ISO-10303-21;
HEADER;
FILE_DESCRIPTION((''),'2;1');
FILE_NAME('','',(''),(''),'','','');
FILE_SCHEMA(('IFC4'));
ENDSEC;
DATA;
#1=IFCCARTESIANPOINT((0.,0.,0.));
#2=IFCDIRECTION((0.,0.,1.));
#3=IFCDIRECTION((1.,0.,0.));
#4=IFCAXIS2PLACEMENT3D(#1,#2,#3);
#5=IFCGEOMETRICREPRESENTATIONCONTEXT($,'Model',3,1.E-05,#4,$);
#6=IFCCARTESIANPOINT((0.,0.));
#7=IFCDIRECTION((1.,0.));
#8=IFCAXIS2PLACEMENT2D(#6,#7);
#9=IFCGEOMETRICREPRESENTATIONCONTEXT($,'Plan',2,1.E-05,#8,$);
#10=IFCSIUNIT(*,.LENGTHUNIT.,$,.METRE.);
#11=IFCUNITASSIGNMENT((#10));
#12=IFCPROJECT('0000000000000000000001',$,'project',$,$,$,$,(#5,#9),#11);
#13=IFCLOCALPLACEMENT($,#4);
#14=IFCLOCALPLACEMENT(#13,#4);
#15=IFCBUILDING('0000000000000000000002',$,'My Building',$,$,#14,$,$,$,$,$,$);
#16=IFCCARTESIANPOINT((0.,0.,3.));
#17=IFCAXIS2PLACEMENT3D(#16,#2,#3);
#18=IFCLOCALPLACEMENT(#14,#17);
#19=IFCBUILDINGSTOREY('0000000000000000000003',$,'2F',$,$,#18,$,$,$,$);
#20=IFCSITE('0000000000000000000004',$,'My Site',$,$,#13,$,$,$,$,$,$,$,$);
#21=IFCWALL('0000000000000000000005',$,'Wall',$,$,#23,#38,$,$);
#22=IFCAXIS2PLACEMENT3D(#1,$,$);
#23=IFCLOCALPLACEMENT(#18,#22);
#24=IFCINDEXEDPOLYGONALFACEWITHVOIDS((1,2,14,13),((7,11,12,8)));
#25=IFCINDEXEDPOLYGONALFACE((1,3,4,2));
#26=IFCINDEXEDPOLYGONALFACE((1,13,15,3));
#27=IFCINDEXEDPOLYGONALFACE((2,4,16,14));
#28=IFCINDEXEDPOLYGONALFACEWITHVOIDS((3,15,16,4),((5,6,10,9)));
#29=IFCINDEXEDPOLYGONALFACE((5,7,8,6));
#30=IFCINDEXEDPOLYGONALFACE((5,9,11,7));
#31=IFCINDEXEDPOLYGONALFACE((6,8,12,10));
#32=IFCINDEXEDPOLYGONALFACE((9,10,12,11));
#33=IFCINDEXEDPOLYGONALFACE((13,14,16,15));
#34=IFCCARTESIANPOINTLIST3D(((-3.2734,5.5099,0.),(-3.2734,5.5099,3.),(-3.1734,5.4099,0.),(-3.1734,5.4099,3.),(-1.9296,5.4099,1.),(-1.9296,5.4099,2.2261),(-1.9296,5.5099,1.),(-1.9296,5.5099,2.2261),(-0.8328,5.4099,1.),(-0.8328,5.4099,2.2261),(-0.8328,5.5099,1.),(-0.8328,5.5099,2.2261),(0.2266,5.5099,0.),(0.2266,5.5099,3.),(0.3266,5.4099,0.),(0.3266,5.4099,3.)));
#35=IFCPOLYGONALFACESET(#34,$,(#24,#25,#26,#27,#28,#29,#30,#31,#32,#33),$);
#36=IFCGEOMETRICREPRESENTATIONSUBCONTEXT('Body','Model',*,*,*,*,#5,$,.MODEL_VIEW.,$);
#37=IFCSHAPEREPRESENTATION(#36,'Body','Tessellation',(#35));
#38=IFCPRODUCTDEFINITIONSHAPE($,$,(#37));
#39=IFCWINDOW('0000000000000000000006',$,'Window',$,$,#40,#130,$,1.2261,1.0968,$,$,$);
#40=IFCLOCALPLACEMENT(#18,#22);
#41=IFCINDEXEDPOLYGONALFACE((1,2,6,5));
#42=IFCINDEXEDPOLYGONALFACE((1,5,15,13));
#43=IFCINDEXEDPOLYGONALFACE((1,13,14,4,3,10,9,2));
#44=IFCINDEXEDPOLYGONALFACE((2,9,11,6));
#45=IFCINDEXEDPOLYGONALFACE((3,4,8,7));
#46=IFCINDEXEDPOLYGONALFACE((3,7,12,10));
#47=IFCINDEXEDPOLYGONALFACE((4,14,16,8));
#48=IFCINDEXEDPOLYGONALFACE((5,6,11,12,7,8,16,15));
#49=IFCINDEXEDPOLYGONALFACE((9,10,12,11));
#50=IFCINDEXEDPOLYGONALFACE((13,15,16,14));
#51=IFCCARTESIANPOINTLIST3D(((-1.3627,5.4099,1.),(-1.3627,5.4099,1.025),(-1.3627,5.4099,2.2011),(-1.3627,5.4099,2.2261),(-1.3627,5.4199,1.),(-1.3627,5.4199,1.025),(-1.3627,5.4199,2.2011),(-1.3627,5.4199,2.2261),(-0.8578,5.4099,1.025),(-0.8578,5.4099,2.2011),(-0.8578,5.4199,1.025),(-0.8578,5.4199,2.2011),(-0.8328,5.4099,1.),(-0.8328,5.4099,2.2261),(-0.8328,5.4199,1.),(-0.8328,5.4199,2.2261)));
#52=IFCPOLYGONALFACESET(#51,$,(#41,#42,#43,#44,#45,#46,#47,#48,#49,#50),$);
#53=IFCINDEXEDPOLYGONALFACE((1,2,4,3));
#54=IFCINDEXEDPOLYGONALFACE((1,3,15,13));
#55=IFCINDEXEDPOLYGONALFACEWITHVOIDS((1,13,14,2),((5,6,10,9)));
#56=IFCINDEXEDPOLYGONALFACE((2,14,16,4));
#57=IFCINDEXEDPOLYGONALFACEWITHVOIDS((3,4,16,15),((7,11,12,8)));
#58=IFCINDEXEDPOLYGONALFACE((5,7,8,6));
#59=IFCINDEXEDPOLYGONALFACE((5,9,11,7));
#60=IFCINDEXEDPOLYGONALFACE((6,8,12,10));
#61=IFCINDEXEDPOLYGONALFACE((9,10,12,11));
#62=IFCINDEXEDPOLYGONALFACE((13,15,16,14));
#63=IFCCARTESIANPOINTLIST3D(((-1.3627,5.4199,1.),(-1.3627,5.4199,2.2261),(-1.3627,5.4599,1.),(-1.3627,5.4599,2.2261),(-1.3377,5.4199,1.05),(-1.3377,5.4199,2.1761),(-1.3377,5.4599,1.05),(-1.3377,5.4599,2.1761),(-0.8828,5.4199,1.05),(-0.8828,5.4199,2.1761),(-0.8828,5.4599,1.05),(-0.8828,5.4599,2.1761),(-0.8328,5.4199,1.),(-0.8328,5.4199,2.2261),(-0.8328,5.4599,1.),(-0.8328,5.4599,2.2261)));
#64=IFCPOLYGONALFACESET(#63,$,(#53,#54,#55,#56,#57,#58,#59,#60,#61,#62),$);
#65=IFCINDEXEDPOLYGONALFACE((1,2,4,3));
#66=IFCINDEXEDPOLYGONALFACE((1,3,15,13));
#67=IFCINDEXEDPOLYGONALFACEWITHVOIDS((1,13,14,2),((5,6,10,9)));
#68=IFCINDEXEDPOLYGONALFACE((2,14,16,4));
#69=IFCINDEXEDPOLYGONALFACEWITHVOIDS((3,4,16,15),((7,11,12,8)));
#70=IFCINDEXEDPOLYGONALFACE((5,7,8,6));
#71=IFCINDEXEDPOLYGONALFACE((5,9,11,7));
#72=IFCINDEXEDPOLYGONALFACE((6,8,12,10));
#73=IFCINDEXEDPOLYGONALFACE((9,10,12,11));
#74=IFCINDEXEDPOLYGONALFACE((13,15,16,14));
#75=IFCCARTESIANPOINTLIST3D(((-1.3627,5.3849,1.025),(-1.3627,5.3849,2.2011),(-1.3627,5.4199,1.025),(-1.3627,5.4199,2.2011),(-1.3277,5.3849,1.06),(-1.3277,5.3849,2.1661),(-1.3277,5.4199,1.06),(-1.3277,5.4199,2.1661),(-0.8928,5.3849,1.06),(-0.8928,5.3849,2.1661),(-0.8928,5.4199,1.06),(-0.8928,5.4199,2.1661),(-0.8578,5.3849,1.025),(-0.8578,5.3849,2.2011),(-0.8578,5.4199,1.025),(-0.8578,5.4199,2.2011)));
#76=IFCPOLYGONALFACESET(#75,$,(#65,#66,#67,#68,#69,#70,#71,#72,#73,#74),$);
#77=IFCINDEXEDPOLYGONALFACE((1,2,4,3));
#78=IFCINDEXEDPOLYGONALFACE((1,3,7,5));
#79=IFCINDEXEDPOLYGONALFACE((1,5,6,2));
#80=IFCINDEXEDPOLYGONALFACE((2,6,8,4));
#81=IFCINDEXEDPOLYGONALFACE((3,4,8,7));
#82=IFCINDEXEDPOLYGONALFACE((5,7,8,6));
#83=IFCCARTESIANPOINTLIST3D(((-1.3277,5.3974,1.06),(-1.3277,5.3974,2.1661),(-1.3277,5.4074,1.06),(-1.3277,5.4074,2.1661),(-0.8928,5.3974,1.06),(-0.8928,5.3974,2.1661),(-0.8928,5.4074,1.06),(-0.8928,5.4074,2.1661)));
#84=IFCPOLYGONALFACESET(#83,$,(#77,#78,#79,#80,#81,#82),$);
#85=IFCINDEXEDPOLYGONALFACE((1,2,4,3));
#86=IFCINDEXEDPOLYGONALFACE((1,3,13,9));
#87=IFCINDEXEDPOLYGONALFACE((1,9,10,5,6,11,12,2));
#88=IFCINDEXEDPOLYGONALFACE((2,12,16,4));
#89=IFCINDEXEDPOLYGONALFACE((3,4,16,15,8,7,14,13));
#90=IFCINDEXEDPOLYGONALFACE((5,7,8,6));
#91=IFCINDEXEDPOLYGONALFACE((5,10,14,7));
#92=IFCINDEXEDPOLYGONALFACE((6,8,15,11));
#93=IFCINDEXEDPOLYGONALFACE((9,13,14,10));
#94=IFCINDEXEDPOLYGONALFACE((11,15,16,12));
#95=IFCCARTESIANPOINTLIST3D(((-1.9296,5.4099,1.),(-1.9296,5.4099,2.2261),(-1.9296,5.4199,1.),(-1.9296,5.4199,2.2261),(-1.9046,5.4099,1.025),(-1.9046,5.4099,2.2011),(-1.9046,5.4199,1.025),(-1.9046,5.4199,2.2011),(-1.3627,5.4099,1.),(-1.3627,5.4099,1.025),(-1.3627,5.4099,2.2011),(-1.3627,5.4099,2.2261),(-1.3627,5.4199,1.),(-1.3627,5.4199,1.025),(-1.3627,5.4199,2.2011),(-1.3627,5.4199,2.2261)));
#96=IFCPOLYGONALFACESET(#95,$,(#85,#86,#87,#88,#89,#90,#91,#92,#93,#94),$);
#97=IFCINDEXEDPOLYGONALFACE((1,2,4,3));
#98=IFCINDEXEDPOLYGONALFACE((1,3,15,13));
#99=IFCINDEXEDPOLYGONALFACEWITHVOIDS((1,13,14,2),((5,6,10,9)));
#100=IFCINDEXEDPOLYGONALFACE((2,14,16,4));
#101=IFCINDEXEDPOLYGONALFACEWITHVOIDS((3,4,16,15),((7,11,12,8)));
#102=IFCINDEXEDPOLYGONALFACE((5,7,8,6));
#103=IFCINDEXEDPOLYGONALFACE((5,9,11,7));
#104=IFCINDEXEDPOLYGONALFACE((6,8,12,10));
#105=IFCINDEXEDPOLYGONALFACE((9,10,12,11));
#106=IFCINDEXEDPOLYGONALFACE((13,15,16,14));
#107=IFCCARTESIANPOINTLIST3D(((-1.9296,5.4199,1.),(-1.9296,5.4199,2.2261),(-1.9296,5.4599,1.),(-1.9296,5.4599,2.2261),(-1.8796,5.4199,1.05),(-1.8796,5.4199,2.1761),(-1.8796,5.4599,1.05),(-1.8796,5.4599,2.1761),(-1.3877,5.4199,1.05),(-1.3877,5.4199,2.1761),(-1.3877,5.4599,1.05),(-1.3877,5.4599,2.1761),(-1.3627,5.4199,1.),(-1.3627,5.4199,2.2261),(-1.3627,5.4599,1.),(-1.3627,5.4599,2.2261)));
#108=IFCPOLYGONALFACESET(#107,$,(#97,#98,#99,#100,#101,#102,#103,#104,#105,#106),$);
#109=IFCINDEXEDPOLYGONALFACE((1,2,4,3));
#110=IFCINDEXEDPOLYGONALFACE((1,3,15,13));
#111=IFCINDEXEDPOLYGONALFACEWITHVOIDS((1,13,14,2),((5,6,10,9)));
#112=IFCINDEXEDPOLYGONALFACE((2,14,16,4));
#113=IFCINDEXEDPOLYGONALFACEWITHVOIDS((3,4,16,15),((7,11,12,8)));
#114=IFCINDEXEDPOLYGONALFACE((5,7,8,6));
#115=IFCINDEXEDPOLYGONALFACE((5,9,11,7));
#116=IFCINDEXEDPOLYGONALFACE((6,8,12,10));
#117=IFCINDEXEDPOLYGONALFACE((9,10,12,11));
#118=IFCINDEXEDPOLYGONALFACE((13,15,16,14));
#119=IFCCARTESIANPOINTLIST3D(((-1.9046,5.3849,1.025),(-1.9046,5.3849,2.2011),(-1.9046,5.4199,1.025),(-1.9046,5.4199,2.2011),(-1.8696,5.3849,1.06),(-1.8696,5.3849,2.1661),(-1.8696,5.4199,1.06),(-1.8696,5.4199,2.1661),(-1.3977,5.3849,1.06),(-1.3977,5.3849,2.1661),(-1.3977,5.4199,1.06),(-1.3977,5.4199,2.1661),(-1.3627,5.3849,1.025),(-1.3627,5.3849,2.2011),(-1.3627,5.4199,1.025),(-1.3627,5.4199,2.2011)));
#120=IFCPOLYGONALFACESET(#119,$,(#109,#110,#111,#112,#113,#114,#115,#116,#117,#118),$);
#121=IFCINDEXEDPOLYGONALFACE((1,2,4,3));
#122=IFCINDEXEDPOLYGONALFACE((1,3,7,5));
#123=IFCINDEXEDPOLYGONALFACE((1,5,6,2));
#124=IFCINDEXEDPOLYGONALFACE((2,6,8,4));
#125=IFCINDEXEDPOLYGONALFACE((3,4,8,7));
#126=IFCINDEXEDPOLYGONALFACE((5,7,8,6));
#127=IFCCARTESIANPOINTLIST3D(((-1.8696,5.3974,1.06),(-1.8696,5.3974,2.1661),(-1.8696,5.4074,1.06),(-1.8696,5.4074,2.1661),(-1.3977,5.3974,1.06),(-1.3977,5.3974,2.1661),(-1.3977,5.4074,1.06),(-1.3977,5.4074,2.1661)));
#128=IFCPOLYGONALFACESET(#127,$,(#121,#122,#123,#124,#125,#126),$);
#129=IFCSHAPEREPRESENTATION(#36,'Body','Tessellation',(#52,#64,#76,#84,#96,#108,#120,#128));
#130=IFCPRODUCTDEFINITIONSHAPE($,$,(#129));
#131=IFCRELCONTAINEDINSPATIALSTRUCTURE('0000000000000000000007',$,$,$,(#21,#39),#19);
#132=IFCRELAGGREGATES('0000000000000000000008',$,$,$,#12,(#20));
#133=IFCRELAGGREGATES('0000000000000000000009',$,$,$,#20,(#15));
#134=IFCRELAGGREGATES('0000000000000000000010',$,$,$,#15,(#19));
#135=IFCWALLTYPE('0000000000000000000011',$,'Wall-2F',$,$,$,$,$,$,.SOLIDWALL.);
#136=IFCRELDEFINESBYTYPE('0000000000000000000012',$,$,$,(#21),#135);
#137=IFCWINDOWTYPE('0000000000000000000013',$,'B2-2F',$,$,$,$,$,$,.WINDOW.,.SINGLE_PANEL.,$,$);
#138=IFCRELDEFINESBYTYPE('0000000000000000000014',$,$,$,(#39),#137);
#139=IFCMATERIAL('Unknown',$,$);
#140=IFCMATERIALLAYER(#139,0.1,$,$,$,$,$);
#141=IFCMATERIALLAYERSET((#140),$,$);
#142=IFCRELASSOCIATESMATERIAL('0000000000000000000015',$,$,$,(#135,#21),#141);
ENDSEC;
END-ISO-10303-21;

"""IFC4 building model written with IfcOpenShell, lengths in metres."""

from ifc_helpers import new_model, entity, si_unit, frame, origin_with_axes, origin_2d_with_axis, place, context, subcontext, project, spatial, line, indexed_curve, outline, extrude, shape, source, transform, mapped, material, layer, layer_set, layer_usage, type_object, type_shapes, element, fill, save


model = new_model("IFC4")

# Units and contexts
model_context = context("Model", 3, precision=1e-05, world=origin_with_axes())
plan_context = context("Plan", 2, precision=1e-05, world=origin_2d_with_axis())
body_context_1 = subcontext(model_context, "Body", "Model", "MODEL_VIEW")
body_context_2 = subcontext(plan_context, "Body", "Plan", "PLAN_VIEW")
ifc_project = project(units=[si_unit("LENGTHUNIT", "METRE")], contexts=[model_context, plan_context])

# Site, building, storey
site_placement = place(None, origin_with_axes())
site = spatial("IfcSite", under=ifc_project, at=site_placement, Name="My Site")
building_placement = place(site_placement, origin_with_axes())
building = spatial("IfcBuilding", under=site, at=building_placement, Name="My Building")
storey_placement = place(building_placement, frame((0.0, 0.0, 3.0), z_axis=(0.0, 0.0, 1.0), x_axis=(1.0, 0.0, 0.0)))
storey = spatial("IfcBuildingStorey", under=building, at=storey_placement, Name="2F")

# Shared definitions
ifc_material = material(Name="Unknown")

# Shared definitions
ifc_layer_1 = layer(ifc_material, 0.1)
ifc_layer_set_1 = layer_set([ifc_layer_1])
wall_type = type_object("IfcWallType", Name="Wall-2F", PredefinedType="SOLIDWALL", material=ifc_layer_set_1)

# Wall, opening, window
ifc_layer_usage_1 = layer_usage(ifc_layer_set_1, "AXIS2", "POSITIVE", 0.0)
wall_1_placement = place(storey_placement, frame((0.2266, 5.5099, 0.0), z_axis=(0.0, 0.0, 1.0), x_axis=(-1.0, 0.0, 0.0)))
wall_1 = element("IfcWall", 1, at=wall_1_placement, inside=storey, type_object=wall_type, material=ifc_layer_usage_1, Name="Wall", context=body_context_1, shape_type="SweptSolid", body=[
    extrude(outline(indexed_curve([(0.0, 0.0), (-0.1, 0.1), (3.4, 0.1), (3.5, 0.0)], segments=[line(1, 2, 3, 4, 1)])), origin_with_axes(), (0.0, 0.0, 1.0), 3.0),
])
shared_shape_1 = source(origin_with_axes(), body_context_1, "Body", "SweptSolid", [
    extrude(outline(indexed_curve([(0.0, 0.0), (1.0968, 0.0), (1.0968, 1.2261), (0.0, 1.2261)], segments=[line(1, 2, 3, 4, 1)])), frame((0.0, -0.6, 0.0), z_axis=(0.0, -1.0, 0.0), x_axis=(1.0, 0.0, 0.0)), (0.0, 0.0, -1.0), 1.2),
])
opening_1_placement = place(wall_1_placement, frame((1.0594, 0.0, 1.0), z_axis=(0.0, 0.0, 1.0), x_axis=(1.0, 0.0, 0.0)))
opening_1 = element("IfcOpeningElement", 2, at=opening_1_placement, cuts=wall_1, PredefinedType="OPENING", context=body_context_1, shape_type="MappedRepresentation", body=[
    mapped(shared_shape_1, transform((0.0, 0.0, 0.0), x_axis=(1.0, 0.0, 0.0), y_axis=(0.0, 1.0, 0.0), z_axis=(0.0, 0.0, 1.0), scale=1.0)),
])
window_type_1 = type_object("IfcWindowType", Name="B2-2F", PartitioningType="SINGLE_PANEL", PredefinedType="WINDOW")
shared_shape_2 = source(origin_with_axes(), body_context_1, "Body", "SweptSolid", [
    extrude(outline(indexed_curve([(0.5299, 0.0), (0.0, 0.0), (0.0, 1.2261), (0.5299, 1.2261), (0.5299, 1.2011), (0.025, 1.2011), (0.025, 0.025), (0.5299, 0.025)], segments=[line(1, 2, 3, 4, 5, 6, 7, 8, 1)])), frame((0.0, 0.09, 0.0), z_axis=(0.0, -1.0, 0.0), x_axis=(1.0, 0.0, 0.0)), (0.0, 0.0, -1.0), 0.01),
    extrude(outline(indexed_curve([(0.0, 0.0), (0.5299, 0.0), (0.5299, 1.2261), (0.0, 1.2261)], segments=[line(1, 2, 3, 4, 1)]), holes=[indexed_curve([(0.05, 0.05), (0.5049, 0.05), (0.5049, 1.1761), (0.05, 1.1761)], segments=[line(1, 2, 3, 4, 1)])]), frame((0.0, 0.05, 0.0), z_axis=(0.0, -1.0, 0.0), x_axis=(1.0, 0.0, 0.0)), (0.0, 0.0, -1.0), 0.04),
    extrude(outline(indexed_curve([(0.0, 0.0), (0.5049, 0.0), (0.5049, 1.1761), (0.0, 1.1761)], segments=[line(1, 2, 3, 4, 1)]), holes=[indexed_curve([(0.035, 0.035), (0.4699, 0.035), (0.4699, 1.1411), (0.035, 1.1411)], segments=[line(1, 2, 3, 4, 1)])]), frame((0.025, 0.09, 0.025), z_axis=(0.0, -1.0, 0.0), x_axis=(1.0, 0.0, 0.0)), (0.0, 0.0, -1.0), 0.035),
    extrude(outline(indexed_curve([(0.035, 0.035), (0.4699, 0.035), (0.4699, 1.1411), (0.035, 1.1411)], segments=[line(1, 2, 3, 4, 1)])), frame((0.025, 0.1025, 0.025), z_axis=(0.0, -1.0, 0.0), x_axis=(1.0, 0.0, 0.0)), (0.0, 0.0, -1.0), 0.01),
    extrude(outline(indexed_curve([(0.0, 1.2261), (0.5669, 1.2261), (0.5669, 0.0), (0.0, 0.0), (0.0, 0.025), (0.5419, 0.025), (0.5419, 1.2011), (0.0, 1.2011)], segments=[line(1, 2, 3, 4, 5, 6, 7, 8, 1)])), frame((0.5299, 0.09, 0.0), z_axis=(0.0, -1.0, 0.0), x_axis=(1.0, 0.0, 0.0)), (0.0, 0.0, -1.0), 0.01),
    extrude(outline(indexed_curve([(0.0, 0.0), (0.5669, 0.0), (0.5669, 1.2261), (0.0, 1.2261)], segments=[line(1, 2, 3, 4, 1)]), holes=[indexed_curve([(0.025, 0.05), (0.5169, 0.05), (0.5169, 1.1761), (0.025, 1.1761)], segments=[line(1, 2, 3, 4, 1)])]), frame((0.5299, 0.05, 0.0), z_axis=(0.0, -1.0, 0.0), x_axis=(1.0, 0.0, 0.0)), (0.0, 0.0, -1.0), 0.04),
    extrude(outline(indexed_curve([(0.0, 0.0), (0.5419, 0.0), (0.5419, 1.1761), (0.0, 1.1761)], segments=[line(1, 2, 3, 4, 1)]), holes=[indexed_curve([(0.035, 0.035), (0.5069, 0.035), (0.5069, 1.1411), (0.035, 1.1411)], segments=[line(1, 2, 3, 4, 1)])]), frame((0.5299, 0.09, 0.025), z_axis=(0.0, -1.0, 0.0), x_axis=(1.0, 0.0, 0.0)), (0.0, 0.0, -1.0), 0.035),
    extrude(outline(indexed_curve([(0.035, 0.035), (0.5069, 0.035), (0.5069, 1.1411), (0.035, 1.1411)], segments=[line(1, 2, 3, 4, 1)])), frame((0.5299, 0.1025, 0.025), z_axis=(0.0, -1.0, 0.0), x_axis=(1.0, 0.0, 0.0)), (0.0, 0.0, -1.0), 0.01),
])
shared_shape_3 = source(origin_with_axes(), body_context_2, "Body", "Curve2D", [
    entity("IfcIndexedPolyCurve", entity("IfcCartesianPointList2D", [[0.05, 0.05], [0.5049, 0.05]])),
    entity("IfcIndexedPolyCurve", entity("IfcCartesianPointList2D", [[0.0, 0.1], [0.025, 0.1], [0.025, 0.09], [0.05, 0.09], [0.05, 0.05], [0.0, 0.05]]), [entity("IfcLineIndex", [1, 2, 3, 4, 5, 6, 1])]),
    entity("IfcIndexedPolyCurve", entity("IfcCartesianPointList2D", [[0.5299, 0.1], [0.5299, 0.1], [0.5299, 0.09], [0.5049, 0.09], [0.5049, 0.05], [0.5299, 0.05]])),
    entity("IfcIndexedPolyCurve", entity("IfcCartesianPointList2D", [[0.025, 0.09], [0.06, 0.09], [0.06, 0.125], [0.025, 0.125]]), [entity("IfcLineIndex", [1, 2, 3, 4, 1])]),
    entity("IfcIndexedPolyCurve", entity("IfcCartesianPointList2D", [[0.5299, 0.09], [0.4949, 0.09], [0.4949, 0.125], [0.5299, 0.125]]), [entity("IfcLineIndex", [1, 2, 3, 4, 1])]),
    entity("IfcIndexedPolyCurve", entity("IfcCartesianPointList2D", [[0.06, 0.09], [0.4949, 0.09]])),
    entity("IfcIndexedPolyCurve", entity("IfcCartesianPointList2D", [[0.06, 0.125], [0.4949, 0.125]])),
    entity("IfcIndexedPolyCurve", entity("IfcCartesianPointList2D", [[0.06, 0.1075], [0.4949, 0.1075]])),
    entity("IfcIndexedPolyCurve", entity("IfcCartesianPointList2D", [[0.5549, 0.05], [1.0468, 0.05]])),
    entity("IfcIndexedPolyCurve", entity("IfcCartesianPointList2D", [[0.5299, 0.1], [0.5299, 0.1], [0.5299, 0.09], [0.5549, 0.09], [0.5549, 0.05], [0.5299, 0.05]])),
    entity("IfcIndexedPolyCurve", entity("IfcCartesianPointList2D", [[1.0968, 0.1], [1.0718, 0.1], [1.0718, 0.09], [1.0468, 0.09], [1.0468, 0.05], [1.0968, 0.05]]), [entity("IfcLineIndex", [1, 2, 3, 4, 5, 6, 1])]),
    entity("IfcIndexedPolyCurve", entity("IfcCartesianPointList2D", [[0.5299, 0.09], [0.5649, 0.09], [0.5649, 0.125], [0.5299, 0.125]]), [entity("IfcLineIndex", [1, 2, 3, 4, 1])]),
    entity("IfcIndexedPolyCurve", entity("IfcCartesianPointList2D", [[1.0718, 0.09], [1.0368, 0.09], [1.0368, 0.125], [1.0718, 0.125]]), [entity("IfcLineIndex", [1, 2, 3, 4, 1])]),
    entity("IfcIndexedPolyCurve", entity("IfcCartesianPointList2D", [[0.5649, 0.09], [1.0368, 0.09]])),
    entity("IfcIndexedPolyCurve", entity("IfcCartesianPointList2D", [[0.5649, 0.125], [1.0368, 0.125]])),
    entity("IfcIndexedPolyCurve", entity("IfcCartesianPointList2D", [[0.5649, 0.1075], [1.0368, 0.1075]])),
])
type_shapes(window_type_1, [shared_shape_2, shared_shape_3])
window_1_placement = place(opening_1_placement, origin_with_axes())
window_1 = element("IfcWindow", 3, at=window_1_placement, inside=storey, type_object=window_type_1, Name="Window", OverallHeight=1.2261, OverallWidth=1.0968, shapes=[
    shape(body_context_1, "Body", "MappedRepresentation", [mapped(shared_shape_2, transform((0.0, 0.0, 0.0), x_axis=(1.0, 0.0, 0.0), y_axis=(0.0, 1.0, 0.0), z_axis=(0.0, 0.0, 1.0), scale=1.0))]),
    shape(body_context_2, "Body", "MappedRepresentation", [mapped(shared_shape_3, transform((0.0, 0.0, 0.0), x_axis=(1.0, 0.0, 0.0), y_axis=(0.0, 1.0, 0.0), z_axis=(0.0, 0.0, 1.0), scale=1.0))]),
])
fill(opening_1, window_1)

save(model, "model.ifc")
